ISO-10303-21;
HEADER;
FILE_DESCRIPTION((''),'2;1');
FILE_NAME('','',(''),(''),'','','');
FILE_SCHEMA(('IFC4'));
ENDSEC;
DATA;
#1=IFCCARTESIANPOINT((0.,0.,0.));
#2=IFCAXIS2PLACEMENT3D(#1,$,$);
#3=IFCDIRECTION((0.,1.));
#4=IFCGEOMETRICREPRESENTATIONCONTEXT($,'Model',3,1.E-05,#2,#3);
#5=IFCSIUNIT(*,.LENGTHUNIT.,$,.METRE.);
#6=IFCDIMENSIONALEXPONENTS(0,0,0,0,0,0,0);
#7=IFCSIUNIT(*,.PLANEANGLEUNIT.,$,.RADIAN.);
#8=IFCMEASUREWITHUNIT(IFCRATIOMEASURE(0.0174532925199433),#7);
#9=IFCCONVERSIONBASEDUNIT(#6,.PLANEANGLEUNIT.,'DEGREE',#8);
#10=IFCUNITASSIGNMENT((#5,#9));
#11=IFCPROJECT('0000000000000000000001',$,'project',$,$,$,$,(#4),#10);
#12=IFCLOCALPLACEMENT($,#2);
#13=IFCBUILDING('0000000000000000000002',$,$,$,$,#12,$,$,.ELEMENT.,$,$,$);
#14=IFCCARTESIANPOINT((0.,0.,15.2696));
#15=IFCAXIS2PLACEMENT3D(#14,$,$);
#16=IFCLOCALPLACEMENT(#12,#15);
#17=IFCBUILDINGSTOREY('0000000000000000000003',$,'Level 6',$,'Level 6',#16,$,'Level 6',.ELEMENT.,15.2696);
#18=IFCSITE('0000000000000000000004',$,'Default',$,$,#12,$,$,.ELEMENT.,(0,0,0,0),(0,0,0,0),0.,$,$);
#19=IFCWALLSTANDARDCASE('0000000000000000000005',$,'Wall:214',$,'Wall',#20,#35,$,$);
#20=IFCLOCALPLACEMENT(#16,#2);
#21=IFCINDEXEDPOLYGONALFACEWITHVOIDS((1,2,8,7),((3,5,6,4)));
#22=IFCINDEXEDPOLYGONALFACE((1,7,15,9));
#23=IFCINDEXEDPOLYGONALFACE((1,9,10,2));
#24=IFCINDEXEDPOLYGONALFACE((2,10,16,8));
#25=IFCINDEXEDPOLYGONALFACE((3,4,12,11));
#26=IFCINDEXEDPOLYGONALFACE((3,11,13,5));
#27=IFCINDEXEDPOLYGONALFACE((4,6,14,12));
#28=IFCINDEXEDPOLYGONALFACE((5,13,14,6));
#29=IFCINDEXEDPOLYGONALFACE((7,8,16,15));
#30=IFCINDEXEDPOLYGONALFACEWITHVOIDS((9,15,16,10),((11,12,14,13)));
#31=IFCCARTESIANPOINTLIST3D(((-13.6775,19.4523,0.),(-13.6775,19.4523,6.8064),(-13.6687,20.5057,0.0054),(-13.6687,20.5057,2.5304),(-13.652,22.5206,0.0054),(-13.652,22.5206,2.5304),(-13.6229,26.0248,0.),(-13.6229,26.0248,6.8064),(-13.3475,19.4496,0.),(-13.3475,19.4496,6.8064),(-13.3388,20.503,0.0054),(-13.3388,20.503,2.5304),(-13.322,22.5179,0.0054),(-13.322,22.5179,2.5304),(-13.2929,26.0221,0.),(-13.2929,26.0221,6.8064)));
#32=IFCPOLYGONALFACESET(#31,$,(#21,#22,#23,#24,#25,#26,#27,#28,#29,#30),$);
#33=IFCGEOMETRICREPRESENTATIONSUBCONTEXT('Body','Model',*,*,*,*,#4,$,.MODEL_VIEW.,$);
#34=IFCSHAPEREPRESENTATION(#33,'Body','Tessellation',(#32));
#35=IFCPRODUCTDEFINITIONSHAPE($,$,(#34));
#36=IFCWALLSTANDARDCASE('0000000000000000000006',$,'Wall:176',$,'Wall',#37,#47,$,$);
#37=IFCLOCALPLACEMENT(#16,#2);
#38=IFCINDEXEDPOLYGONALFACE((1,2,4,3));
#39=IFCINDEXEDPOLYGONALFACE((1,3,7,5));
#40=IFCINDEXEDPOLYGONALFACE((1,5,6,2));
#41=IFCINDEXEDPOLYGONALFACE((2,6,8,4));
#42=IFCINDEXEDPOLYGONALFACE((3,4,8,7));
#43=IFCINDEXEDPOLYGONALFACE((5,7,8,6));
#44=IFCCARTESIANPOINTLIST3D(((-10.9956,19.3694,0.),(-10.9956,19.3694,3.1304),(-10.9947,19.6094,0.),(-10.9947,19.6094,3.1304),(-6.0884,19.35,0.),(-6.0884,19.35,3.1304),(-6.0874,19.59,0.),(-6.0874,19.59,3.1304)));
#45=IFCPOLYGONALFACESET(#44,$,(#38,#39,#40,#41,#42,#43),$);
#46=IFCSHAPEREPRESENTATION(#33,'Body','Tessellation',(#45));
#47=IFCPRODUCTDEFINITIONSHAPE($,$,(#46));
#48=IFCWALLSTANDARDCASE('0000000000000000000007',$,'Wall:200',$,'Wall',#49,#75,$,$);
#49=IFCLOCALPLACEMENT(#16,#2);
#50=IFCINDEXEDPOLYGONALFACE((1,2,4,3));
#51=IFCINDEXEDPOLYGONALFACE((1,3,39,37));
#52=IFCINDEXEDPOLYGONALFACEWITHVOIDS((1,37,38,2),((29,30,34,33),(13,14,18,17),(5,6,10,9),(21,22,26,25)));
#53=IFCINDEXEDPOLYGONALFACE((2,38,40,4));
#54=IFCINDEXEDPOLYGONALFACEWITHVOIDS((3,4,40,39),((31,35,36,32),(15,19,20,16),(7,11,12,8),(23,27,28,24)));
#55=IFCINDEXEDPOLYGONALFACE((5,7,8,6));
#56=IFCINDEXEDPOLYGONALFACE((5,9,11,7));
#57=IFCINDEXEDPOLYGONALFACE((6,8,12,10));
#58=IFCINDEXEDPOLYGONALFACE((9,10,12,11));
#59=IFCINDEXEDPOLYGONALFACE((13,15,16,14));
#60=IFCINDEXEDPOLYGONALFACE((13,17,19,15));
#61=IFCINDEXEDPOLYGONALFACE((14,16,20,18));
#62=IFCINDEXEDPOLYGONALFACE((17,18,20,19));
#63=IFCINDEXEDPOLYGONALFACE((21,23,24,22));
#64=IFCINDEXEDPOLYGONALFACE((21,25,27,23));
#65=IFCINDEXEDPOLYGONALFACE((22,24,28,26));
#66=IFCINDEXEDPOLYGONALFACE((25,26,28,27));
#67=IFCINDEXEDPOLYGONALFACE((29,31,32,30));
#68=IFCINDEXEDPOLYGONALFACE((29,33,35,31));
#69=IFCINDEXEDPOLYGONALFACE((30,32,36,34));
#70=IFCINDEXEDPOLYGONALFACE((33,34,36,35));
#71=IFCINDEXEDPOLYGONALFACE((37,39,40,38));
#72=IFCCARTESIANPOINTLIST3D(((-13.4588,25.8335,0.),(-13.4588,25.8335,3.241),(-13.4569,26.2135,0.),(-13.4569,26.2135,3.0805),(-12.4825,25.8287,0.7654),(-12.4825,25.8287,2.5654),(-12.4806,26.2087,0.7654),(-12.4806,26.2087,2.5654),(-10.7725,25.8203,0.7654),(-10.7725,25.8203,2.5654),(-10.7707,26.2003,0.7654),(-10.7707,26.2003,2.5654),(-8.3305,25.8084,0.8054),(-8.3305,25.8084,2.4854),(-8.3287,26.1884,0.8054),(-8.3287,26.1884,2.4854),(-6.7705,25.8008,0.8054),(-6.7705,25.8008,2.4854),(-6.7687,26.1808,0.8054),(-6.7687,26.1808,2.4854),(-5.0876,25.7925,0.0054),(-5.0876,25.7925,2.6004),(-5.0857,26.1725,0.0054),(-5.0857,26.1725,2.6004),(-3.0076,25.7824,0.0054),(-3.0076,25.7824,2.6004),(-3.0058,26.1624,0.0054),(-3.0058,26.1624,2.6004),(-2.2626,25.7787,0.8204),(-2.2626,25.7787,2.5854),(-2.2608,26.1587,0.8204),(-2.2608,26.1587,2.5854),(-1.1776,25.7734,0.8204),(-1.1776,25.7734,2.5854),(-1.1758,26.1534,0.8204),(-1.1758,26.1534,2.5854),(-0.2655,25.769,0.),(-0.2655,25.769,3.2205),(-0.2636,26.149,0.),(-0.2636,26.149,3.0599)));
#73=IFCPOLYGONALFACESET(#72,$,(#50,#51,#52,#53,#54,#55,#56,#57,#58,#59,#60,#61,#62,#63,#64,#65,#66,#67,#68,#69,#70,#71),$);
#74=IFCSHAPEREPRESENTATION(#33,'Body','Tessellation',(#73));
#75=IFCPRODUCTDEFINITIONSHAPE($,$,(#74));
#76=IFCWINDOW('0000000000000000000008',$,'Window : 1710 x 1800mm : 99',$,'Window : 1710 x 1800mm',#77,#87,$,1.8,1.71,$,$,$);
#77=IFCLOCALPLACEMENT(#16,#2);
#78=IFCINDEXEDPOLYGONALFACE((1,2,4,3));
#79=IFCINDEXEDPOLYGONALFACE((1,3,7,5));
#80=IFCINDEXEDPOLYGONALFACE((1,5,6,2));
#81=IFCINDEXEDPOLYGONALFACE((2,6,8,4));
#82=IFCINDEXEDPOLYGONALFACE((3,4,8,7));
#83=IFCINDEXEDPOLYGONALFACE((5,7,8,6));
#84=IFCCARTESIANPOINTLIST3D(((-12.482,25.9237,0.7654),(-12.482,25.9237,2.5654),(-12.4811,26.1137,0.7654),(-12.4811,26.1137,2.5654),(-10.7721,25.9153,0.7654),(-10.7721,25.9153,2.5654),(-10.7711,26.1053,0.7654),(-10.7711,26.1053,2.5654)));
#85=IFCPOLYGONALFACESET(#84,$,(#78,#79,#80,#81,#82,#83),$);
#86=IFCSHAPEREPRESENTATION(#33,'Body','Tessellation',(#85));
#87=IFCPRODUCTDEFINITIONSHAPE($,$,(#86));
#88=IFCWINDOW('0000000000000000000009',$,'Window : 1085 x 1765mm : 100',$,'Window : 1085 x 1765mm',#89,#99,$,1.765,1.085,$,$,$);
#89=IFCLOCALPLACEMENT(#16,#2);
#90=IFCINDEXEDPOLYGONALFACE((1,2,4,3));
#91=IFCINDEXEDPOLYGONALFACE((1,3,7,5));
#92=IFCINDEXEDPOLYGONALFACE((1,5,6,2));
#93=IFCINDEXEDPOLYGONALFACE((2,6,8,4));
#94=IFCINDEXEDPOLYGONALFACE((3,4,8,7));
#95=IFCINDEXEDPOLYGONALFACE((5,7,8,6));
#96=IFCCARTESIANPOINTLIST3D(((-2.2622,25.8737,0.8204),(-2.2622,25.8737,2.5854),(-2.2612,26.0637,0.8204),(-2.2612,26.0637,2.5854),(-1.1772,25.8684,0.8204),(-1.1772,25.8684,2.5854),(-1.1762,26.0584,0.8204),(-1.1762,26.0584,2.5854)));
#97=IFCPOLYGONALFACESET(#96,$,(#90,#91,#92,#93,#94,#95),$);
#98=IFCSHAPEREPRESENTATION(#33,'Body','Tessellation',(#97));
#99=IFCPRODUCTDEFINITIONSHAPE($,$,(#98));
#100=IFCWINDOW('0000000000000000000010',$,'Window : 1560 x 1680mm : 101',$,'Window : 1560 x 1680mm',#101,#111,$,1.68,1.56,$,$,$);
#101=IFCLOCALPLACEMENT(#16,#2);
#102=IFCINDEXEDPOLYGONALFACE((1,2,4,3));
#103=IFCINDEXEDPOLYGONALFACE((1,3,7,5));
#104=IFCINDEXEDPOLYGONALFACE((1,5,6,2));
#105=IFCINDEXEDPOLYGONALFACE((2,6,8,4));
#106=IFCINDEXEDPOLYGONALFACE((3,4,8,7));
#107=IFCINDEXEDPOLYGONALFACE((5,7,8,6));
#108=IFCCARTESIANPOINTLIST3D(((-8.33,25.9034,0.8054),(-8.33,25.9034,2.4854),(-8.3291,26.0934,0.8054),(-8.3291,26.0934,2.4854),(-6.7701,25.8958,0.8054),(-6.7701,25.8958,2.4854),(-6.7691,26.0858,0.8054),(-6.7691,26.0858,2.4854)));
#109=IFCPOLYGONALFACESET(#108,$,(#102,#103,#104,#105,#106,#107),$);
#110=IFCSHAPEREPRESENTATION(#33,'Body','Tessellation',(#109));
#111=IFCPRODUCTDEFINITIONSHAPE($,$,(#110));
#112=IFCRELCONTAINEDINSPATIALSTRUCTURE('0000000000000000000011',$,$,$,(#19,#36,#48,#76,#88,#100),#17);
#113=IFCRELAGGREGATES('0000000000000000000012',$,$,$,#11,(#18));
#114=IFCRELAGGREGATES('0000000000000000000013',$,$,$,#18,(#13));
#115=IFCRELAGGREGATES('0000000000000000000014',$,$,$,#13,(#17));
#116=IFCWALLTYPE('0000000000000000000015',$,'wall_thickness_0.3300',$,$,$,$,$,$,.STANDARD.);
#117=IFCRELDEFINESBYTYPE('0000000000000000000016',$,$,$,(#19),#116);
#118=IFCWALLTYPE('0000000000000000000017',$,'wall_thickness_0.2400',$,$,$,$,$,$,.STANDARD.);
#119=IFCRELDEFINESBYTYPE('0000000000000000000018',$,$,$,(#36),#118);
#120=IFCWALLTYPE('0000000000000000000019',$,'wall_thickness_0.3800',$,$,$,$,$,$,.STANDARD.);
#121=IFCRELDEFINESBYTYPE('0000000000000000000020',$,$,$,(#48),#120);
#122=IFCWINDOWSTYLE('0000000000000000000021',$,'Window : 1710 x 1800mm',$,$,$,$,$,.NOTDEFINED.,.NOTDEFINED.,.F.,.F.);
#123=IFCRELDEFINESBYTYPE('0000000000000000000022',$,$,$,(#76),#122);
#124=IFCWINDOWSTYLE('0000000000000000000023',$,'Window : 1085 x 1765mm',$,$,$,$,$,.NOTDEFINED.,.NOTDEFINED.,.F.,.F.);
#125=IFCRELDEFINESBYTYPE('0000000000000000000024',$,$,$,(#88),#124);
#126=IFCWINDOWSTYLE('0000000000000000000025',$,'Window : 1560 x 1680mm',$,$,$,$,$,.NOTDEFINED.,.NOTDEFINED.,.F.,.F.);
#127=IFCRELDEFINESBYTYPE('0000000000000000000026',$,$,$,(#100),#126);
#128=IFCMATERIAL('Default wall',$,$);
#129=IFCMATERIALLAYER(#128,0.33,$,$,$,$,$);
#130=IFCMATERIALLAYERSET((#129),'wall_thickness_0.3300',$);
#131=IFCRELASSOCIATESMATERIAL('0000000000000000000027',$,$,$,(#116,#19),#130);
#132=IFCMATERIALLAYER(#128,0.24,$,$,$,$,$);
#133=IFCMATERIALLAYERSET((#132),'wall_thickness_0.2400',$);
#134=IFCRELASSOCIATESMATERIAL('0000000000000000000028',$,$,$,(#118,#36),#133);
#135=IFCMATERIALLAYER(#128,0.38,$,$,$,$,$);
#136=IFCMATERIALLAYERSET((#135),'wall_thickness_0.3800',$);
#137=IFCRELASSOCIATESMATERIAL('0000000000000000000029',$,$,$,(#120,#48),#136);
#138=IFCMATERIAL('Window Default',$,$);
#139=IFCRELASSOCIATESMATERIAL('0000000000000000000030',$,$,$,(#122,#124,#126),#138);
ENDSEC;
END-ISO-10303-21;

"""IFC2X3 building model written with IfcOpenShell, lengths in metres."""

from ifc_helpers import new_model, entity, si_unit, converted_unit, direction, frame, frame_2d, origin, origin_2d_with_axis, place, context, subcontext, project, spatial, polyline, rectangle, outline, extrude, clip, halfspace, source, transform, mapped, material, layer, layer_set, layer_usage, type_object, type_shapes, element, fill, save


model = new_model("IFC2X3")

# Units and contexts
model_context = context("Model", 3, precision=1e-05, world=origin(), true_north=direction((0.0, 1.0)))
body_context = subcontext(model_context, "Body", "Model", "MODEL_VIEW")
ifc_project = project(units=[si_unit("LENGTHUNIT", "METRE"), converted_unit("PLANEANGLEUNIT", "DEGREE", entity("IfcRatioMeasure", 0.0174532925199433), si_unit("PLANEANGLEUNIT", "RADIAN"), dimensions=[0, 0, 0, 0, 0, 0, 0])], contexts=[model_context])

# Site, building, storey
placement = place(None, origin())
site = spatial("IfcSite", under=ifc_project, at=placement, Name="Default", CompositionType="ELEMENT", RefLatitude=(0, 0, 0, 0), RefLongitude=(0, 0, 0, 0), RefElevation=0.0)
building = spatial("IfcBuilding", under=site, at=placement, CompositionType="ELEMENT")
storey_placement = place(placement, frame((0.0, 0.0, 15.2696)))
storey = spatial("IfcBuildingStorey", under=building, at=storey_placement, Name="Level 6", ObjectType="Level 6", LongName="Level 6", CompositionType="ELEMENT", Elevation=15.2696)

# Shared definitions
ifc_material_1 = material(Name="Default wall")

# Shared definitions
ifc_layer_1 = layer(ifc_material_1, 0.33)
ifc_layer_set_1 = layer_set([ifc_layer_1], Name="wall_thickness_0.3300")
ifc_layer_usage_1 = layer_usage(ifc_layer_set_1, "AXIS2", "POSITIVE", -0.165)
wall_type_1 = type_object("IfcWallType", Name="wall_thickness_0.3300", PredefinedType="STANDARD", material=ifc_layer_set_1)
ifc_material_2 = material(Name="Window Default")

# Wall, opening
wall_1_placement = place(storey_placement, frame((-13.4579, 26.0235, 0.0), z_axis=(0.0, 0.0, 1.0), x_axis=(-0.008313, -0.999965, 0.0)))
wall_1 = element("IfcWallStandardCase", 1, at=wall_1_placement, inside=storey, type_object=wall_type_1, material=ifc_layer_usage_1, Name="Wall:214", ObjectType="Wall", context=body_context, shape_type="SweptSolid", body=[
    extrude(outline(polyline([(6.5728, -0.165), (6.5728, 0.165), (0.0, 0.165), (0.0, -0.165), (6.5728, -0.165)])), origin(), (0.0, 0.0, 1.0), 6.8064),
])
opening_1_placement = place(wall_1_placement, frame((3.5043, -0.165, 0.0054)))
element("IfcOpeningElement", 2, at=opening_1_placement, cuts=wall_1, ObjectType="Opening", context=body_context, shape_type="SweptSolid", body=[
    extrude(rectangle(XDim=2.015, YDim=2.525, at=frame_2d((1.2625, 1.0075), x_axis=(0.0, 1.0))), frame((0.0, 0.0, 0.0), z_axis=(0.0, 1.0, 0.0), x_axis=(0.0, 0.0, 1.0)), (0.0, 0.0, 1.0), 0.33),
])

# Wall
ifc_layer_2 = layer(ifc_material_1, 0.24)
ifc_layer_set_2 = layer_set([ifc_layer_2], Name="wall_thickness_0.2400")
ifc_layer_usage_2 = layer_usage(ifc_layer_set_2, "AXIS2", "POSITIVE", -0.12)
wall_type_2 = type_object("IfcWallType", Name="wall_thickness_0.2400", PredefinedType="STANDARD", material=ifc_layer_set_2)
wall_2_placement = place(storey_placement, frame((-10.9952, 19.4894, 0.0), z_axis=(0.0, 0.0, 1.0), x_axis=(0.999992, -0.003952, 0.0)))
element("IfcWallStandardCase", 3, at=wall_2_placement, inside=storey, type_object=wall_type_2, material=ifc_layer_usage_2, Name="Wall:176", ObjectType="Wall", context=body_context, shape_type="Clipping", body=[
    clip(extrude(outline(polyline([(4.9073, -0.12), (4.9073, 0.12), (0.0, 0.12), (0.0, -0.12), (4.9073, -0.12)])), origin(), (0.0, 0.0, 1.0), 3.1304), halfspace(frame((-1.0384, 0.1004, 5.7956), z_axis=(-0.002756, -0.389132, 0.921178), x_axis=(0.999983, -0.005854, 0.000518)), False)),
])

# Wall, openings, windows
ifc_layer_3 = layer(ifc_material_1, 0.38)
ifc_layer_set_3 = layer_set([ifc_layer_3], Name="wall_thickness_0.3800")
ifc_layer_usage_3 = layer_usage(ifc_layer_set_3, "AXIS2", "POSITIVE", -0.19)
wall_type_3 = type_object("IfcWallType", Name="wall_thickness_0.3800", PredefinedType="STANDARD", material=ifc_layer_set_3)
wall_3_placement = place(storey_placement, frame((-13.4579, 26.0235, 0.0), z_axis=(0.0, 0.0, 1.0), x_axis=(0.999988, -0.004889, 0.0)))
wall_3 = element("IfcWallStandardCase", 4, at=wall_3_placement, inside=storey, type_object=wall_type_3, material=ifc_layer_usage_3, Name="Wall:200", ObjectType="Wall", context=body_context, shape_type="Clipping", body=[
    clip(extrude(outline(polyline([(13.1935, -0.19), (13.1935, 0.19), (0.0, 0.19), (0.0, -0.19), (13.1935, -0.19)])), origin(), (0.0, 0.0, 1.0), 5.1204), halfspace(frame((37.8704, -6.6016, 5.8904), z_axis=(0.001436, 0.389134, 0.92118), x_axis=(-0.999988, 0.004917, -0.000518)), False)),
])
opening_2_placement = place(wall_3_placement, frame((8.3713, -0.19, 0.0054)))
element("IfcOpeningElement", 5, at=opening_2_placement, cuts=wall_3, ObjectType="Opening", context=body_context, shape_type="SweptSolid", body=[
    extrude(rectangle(XDim=2.08, YDim=2.595, at=frame_2d((1.2975, 1.04), x_axis=(0.0, 1.0))), frame((0.0, 0.0, 0.0), z_axis=(0.0, 1.0, 0.0), x_axis=(0.0, 0.0, 1.0)), (0.0, 0.0, 1.0), 0.38),
])
opening_3_placement = place(wall_3_placement, frame((0.9763, -0.19, 0.7654)))
opening_3 = element("IfcOpeningElement", 6, at=opening_3_placement, cuts=wall_3, ObjectType="Opening", context=body_context, shape_type="SweptSolid", body=[
    extrude(rectangle(XDim=1.71, YDim=1.8, at=frame_2d((0.9, 0.855), x_axis=(0.0, 1.0))), frame((0.0, 0.0, 0.0), z_axis=(0.0, 1.0, 0.0), x_axis=(0.0, 0.0, 1.0)), (0.0, 0.0, 1.0), 0.38),
])
opening_4_placement = place(wall_3_placement, frame((11.1963, -0.19, 0.8204)))
opening_4 = element("IfcOpeningElement", 7, at=opening_4_placement, cuts=wall_3, ObjectType="Opening", context=body_context, shape_type="SweptSolid", body=[
    extrude(rectangle(XDim=1.085, YDim=1.765, at=frame_2d((0.8825, 0.5425), x_axis=(0.0, 1.0))), frame((0.0, 0.0, 0.0), z_axis=(0.0, 1.0, 0.0), x_axis=(0.0, 0.0, 1.0)), (0.0, 0.0, 1.0), 0.38),
])
opening_5_placement = place(wall_3_placement, frame((5.1284, -0.19, 0.8054)))
opening_5 = element("IfcOpeningElement", 8, at=opening_5_placement, cuts=wall_3, ObjectType="Opening", context=body_context, shape_type="SweptSolid", body=[
    extrude(rectangle(XDim=1.56, YDim=1.68, at=frame_2d((0.84, 0.78), x_axis=(0.0, 1.0))), frame((0.0, 0.0, 0.0), z_axis=(0.0, 1.0, 0.0), x_axis=(0.0, 0.0, 1.0)), (0.0, 0.0, 1.0), 0.38),
])
window_style_1 = type_object("IfcWindowStyle", Name="Window : 1710 x 1800mm", ConstructionType="NOTDEFINED", OperationType="NOTDEFINED", ParameterTakesPrecedence=False, Sizeable=False, material=ifc_material_2)
shared_shape_1 = source(origin(), body_context, "Body", "SweptSolid", [
    extrude(rectangle(XDim=0.19, YDim=1.71, at=origin_2d_with_axis()), frame((0.855, 0.19, 0.0), z_axis=(0.0, 0.0, 1.0), x_axis=(0.0, 1.0, 0.0)), (0.0, 0.0, 1.0), 1.8),
])
type_shapes(window_style_1, [shared_shape_1])
window_1_placement = place(opening_3_placement, origin())
window_1 = element("IfcWindow", 9, at=window_1_placement, inside=storey, type_object=window_style_1, Name="Window : 1710 x 1800mm : 99", ObjectType="Window : 1710 x 1800mm", OverallHeight=1.8, OverallWidth=1.71, context=body_context, shape_type="MappedRepresentation", body=[
    mapped(shared_shape_1, transform((0.0, 0.0, 0.0), scale=1.0)),
])
fill(opening_3, window_1)
window_style_2 = type_object("IfcWindowStyle", Name="Window : 1085 x 1765mm", ConstructionType="NOTDEFINED", OperationType="NOTDEFINED", ParameterTakesPrecedence=False, Sizeable=False, material=ifc_material_2)
shared_shape_2 = source(origin(), body_context, "Body", "SweptSolid", [
    extrude(rectangle(XDim=0.19, YDim=1.085, at=origin_2d_with_axis()), frame((0.5425, 0.19, 0.0), z_axis=(0.0, 0.0, 1.0), x_axis=(0.0, 1.0, 0.0)), (0.0, 0.0, 1.0), 1.765),
])
type_shapes(window_style_2, [shared_shape_2])
window_2_placement = place(opening_4_placement, origin())
window_2 = element("IfcWindow", 10, at=window_2_placement, inside=storey, type_object=window_style_2, Name="Window : 1085 x 1765mm : 100", ObjectType="Window : 1085 x 1765mm", OverallHeight=1.765, OverallWidth=1.085, context=body_context, shape_type="MappedRepresentation", body=[
    mapped(shared_shape_2, transform((0.0, 0.0, 0.0), scale=1.0)),
])
fill(opening_4, window_2)
window_style_3 = type_object("IfcWindowStyle", Name="Window : 1560 x 1680mm", ConstructionType="NOTDEFINED", OperationType="NOTDEFINED", ParameterTakesPrecedence=False, Sizeable=False, material=ifc_material_2)
shared_shape_3 = source(origin(), body_context, "Body", "SweptSolid", [
    extrude(rectangle(XDim=0.19, YDim=1.56, at=origin_2d_with_axis()), frame((0.78, 0.19, 0.0), z_axis=(0.0, 0.0, 1.0), x_axis=(0.0, 1.0, 0.0)), (0.0, 0.0, 1.0), 1.68),
])
type_shapes(window_style_3, [shared_shape_3])
window_3_placement = place(opening_5_placement, origin())
window_3 = element("IfcWindow", 11, at=window_3_placement, inside=storey, type_object=window_style_3, Name="Window : 1560 x 1680mm : 101", ObjectType="Window : 1560 x 1680mm", OverallHeight=1.68, OverallWidth=1.56, context=body_context, shape_type="MappedRepresentation", body=[
    mapped(shared_shape_3, transform((0.0, 0.0, 0.0), scale=1.0)),
])
fill(opening_5, window_3)

save(model, "model.ifc")
